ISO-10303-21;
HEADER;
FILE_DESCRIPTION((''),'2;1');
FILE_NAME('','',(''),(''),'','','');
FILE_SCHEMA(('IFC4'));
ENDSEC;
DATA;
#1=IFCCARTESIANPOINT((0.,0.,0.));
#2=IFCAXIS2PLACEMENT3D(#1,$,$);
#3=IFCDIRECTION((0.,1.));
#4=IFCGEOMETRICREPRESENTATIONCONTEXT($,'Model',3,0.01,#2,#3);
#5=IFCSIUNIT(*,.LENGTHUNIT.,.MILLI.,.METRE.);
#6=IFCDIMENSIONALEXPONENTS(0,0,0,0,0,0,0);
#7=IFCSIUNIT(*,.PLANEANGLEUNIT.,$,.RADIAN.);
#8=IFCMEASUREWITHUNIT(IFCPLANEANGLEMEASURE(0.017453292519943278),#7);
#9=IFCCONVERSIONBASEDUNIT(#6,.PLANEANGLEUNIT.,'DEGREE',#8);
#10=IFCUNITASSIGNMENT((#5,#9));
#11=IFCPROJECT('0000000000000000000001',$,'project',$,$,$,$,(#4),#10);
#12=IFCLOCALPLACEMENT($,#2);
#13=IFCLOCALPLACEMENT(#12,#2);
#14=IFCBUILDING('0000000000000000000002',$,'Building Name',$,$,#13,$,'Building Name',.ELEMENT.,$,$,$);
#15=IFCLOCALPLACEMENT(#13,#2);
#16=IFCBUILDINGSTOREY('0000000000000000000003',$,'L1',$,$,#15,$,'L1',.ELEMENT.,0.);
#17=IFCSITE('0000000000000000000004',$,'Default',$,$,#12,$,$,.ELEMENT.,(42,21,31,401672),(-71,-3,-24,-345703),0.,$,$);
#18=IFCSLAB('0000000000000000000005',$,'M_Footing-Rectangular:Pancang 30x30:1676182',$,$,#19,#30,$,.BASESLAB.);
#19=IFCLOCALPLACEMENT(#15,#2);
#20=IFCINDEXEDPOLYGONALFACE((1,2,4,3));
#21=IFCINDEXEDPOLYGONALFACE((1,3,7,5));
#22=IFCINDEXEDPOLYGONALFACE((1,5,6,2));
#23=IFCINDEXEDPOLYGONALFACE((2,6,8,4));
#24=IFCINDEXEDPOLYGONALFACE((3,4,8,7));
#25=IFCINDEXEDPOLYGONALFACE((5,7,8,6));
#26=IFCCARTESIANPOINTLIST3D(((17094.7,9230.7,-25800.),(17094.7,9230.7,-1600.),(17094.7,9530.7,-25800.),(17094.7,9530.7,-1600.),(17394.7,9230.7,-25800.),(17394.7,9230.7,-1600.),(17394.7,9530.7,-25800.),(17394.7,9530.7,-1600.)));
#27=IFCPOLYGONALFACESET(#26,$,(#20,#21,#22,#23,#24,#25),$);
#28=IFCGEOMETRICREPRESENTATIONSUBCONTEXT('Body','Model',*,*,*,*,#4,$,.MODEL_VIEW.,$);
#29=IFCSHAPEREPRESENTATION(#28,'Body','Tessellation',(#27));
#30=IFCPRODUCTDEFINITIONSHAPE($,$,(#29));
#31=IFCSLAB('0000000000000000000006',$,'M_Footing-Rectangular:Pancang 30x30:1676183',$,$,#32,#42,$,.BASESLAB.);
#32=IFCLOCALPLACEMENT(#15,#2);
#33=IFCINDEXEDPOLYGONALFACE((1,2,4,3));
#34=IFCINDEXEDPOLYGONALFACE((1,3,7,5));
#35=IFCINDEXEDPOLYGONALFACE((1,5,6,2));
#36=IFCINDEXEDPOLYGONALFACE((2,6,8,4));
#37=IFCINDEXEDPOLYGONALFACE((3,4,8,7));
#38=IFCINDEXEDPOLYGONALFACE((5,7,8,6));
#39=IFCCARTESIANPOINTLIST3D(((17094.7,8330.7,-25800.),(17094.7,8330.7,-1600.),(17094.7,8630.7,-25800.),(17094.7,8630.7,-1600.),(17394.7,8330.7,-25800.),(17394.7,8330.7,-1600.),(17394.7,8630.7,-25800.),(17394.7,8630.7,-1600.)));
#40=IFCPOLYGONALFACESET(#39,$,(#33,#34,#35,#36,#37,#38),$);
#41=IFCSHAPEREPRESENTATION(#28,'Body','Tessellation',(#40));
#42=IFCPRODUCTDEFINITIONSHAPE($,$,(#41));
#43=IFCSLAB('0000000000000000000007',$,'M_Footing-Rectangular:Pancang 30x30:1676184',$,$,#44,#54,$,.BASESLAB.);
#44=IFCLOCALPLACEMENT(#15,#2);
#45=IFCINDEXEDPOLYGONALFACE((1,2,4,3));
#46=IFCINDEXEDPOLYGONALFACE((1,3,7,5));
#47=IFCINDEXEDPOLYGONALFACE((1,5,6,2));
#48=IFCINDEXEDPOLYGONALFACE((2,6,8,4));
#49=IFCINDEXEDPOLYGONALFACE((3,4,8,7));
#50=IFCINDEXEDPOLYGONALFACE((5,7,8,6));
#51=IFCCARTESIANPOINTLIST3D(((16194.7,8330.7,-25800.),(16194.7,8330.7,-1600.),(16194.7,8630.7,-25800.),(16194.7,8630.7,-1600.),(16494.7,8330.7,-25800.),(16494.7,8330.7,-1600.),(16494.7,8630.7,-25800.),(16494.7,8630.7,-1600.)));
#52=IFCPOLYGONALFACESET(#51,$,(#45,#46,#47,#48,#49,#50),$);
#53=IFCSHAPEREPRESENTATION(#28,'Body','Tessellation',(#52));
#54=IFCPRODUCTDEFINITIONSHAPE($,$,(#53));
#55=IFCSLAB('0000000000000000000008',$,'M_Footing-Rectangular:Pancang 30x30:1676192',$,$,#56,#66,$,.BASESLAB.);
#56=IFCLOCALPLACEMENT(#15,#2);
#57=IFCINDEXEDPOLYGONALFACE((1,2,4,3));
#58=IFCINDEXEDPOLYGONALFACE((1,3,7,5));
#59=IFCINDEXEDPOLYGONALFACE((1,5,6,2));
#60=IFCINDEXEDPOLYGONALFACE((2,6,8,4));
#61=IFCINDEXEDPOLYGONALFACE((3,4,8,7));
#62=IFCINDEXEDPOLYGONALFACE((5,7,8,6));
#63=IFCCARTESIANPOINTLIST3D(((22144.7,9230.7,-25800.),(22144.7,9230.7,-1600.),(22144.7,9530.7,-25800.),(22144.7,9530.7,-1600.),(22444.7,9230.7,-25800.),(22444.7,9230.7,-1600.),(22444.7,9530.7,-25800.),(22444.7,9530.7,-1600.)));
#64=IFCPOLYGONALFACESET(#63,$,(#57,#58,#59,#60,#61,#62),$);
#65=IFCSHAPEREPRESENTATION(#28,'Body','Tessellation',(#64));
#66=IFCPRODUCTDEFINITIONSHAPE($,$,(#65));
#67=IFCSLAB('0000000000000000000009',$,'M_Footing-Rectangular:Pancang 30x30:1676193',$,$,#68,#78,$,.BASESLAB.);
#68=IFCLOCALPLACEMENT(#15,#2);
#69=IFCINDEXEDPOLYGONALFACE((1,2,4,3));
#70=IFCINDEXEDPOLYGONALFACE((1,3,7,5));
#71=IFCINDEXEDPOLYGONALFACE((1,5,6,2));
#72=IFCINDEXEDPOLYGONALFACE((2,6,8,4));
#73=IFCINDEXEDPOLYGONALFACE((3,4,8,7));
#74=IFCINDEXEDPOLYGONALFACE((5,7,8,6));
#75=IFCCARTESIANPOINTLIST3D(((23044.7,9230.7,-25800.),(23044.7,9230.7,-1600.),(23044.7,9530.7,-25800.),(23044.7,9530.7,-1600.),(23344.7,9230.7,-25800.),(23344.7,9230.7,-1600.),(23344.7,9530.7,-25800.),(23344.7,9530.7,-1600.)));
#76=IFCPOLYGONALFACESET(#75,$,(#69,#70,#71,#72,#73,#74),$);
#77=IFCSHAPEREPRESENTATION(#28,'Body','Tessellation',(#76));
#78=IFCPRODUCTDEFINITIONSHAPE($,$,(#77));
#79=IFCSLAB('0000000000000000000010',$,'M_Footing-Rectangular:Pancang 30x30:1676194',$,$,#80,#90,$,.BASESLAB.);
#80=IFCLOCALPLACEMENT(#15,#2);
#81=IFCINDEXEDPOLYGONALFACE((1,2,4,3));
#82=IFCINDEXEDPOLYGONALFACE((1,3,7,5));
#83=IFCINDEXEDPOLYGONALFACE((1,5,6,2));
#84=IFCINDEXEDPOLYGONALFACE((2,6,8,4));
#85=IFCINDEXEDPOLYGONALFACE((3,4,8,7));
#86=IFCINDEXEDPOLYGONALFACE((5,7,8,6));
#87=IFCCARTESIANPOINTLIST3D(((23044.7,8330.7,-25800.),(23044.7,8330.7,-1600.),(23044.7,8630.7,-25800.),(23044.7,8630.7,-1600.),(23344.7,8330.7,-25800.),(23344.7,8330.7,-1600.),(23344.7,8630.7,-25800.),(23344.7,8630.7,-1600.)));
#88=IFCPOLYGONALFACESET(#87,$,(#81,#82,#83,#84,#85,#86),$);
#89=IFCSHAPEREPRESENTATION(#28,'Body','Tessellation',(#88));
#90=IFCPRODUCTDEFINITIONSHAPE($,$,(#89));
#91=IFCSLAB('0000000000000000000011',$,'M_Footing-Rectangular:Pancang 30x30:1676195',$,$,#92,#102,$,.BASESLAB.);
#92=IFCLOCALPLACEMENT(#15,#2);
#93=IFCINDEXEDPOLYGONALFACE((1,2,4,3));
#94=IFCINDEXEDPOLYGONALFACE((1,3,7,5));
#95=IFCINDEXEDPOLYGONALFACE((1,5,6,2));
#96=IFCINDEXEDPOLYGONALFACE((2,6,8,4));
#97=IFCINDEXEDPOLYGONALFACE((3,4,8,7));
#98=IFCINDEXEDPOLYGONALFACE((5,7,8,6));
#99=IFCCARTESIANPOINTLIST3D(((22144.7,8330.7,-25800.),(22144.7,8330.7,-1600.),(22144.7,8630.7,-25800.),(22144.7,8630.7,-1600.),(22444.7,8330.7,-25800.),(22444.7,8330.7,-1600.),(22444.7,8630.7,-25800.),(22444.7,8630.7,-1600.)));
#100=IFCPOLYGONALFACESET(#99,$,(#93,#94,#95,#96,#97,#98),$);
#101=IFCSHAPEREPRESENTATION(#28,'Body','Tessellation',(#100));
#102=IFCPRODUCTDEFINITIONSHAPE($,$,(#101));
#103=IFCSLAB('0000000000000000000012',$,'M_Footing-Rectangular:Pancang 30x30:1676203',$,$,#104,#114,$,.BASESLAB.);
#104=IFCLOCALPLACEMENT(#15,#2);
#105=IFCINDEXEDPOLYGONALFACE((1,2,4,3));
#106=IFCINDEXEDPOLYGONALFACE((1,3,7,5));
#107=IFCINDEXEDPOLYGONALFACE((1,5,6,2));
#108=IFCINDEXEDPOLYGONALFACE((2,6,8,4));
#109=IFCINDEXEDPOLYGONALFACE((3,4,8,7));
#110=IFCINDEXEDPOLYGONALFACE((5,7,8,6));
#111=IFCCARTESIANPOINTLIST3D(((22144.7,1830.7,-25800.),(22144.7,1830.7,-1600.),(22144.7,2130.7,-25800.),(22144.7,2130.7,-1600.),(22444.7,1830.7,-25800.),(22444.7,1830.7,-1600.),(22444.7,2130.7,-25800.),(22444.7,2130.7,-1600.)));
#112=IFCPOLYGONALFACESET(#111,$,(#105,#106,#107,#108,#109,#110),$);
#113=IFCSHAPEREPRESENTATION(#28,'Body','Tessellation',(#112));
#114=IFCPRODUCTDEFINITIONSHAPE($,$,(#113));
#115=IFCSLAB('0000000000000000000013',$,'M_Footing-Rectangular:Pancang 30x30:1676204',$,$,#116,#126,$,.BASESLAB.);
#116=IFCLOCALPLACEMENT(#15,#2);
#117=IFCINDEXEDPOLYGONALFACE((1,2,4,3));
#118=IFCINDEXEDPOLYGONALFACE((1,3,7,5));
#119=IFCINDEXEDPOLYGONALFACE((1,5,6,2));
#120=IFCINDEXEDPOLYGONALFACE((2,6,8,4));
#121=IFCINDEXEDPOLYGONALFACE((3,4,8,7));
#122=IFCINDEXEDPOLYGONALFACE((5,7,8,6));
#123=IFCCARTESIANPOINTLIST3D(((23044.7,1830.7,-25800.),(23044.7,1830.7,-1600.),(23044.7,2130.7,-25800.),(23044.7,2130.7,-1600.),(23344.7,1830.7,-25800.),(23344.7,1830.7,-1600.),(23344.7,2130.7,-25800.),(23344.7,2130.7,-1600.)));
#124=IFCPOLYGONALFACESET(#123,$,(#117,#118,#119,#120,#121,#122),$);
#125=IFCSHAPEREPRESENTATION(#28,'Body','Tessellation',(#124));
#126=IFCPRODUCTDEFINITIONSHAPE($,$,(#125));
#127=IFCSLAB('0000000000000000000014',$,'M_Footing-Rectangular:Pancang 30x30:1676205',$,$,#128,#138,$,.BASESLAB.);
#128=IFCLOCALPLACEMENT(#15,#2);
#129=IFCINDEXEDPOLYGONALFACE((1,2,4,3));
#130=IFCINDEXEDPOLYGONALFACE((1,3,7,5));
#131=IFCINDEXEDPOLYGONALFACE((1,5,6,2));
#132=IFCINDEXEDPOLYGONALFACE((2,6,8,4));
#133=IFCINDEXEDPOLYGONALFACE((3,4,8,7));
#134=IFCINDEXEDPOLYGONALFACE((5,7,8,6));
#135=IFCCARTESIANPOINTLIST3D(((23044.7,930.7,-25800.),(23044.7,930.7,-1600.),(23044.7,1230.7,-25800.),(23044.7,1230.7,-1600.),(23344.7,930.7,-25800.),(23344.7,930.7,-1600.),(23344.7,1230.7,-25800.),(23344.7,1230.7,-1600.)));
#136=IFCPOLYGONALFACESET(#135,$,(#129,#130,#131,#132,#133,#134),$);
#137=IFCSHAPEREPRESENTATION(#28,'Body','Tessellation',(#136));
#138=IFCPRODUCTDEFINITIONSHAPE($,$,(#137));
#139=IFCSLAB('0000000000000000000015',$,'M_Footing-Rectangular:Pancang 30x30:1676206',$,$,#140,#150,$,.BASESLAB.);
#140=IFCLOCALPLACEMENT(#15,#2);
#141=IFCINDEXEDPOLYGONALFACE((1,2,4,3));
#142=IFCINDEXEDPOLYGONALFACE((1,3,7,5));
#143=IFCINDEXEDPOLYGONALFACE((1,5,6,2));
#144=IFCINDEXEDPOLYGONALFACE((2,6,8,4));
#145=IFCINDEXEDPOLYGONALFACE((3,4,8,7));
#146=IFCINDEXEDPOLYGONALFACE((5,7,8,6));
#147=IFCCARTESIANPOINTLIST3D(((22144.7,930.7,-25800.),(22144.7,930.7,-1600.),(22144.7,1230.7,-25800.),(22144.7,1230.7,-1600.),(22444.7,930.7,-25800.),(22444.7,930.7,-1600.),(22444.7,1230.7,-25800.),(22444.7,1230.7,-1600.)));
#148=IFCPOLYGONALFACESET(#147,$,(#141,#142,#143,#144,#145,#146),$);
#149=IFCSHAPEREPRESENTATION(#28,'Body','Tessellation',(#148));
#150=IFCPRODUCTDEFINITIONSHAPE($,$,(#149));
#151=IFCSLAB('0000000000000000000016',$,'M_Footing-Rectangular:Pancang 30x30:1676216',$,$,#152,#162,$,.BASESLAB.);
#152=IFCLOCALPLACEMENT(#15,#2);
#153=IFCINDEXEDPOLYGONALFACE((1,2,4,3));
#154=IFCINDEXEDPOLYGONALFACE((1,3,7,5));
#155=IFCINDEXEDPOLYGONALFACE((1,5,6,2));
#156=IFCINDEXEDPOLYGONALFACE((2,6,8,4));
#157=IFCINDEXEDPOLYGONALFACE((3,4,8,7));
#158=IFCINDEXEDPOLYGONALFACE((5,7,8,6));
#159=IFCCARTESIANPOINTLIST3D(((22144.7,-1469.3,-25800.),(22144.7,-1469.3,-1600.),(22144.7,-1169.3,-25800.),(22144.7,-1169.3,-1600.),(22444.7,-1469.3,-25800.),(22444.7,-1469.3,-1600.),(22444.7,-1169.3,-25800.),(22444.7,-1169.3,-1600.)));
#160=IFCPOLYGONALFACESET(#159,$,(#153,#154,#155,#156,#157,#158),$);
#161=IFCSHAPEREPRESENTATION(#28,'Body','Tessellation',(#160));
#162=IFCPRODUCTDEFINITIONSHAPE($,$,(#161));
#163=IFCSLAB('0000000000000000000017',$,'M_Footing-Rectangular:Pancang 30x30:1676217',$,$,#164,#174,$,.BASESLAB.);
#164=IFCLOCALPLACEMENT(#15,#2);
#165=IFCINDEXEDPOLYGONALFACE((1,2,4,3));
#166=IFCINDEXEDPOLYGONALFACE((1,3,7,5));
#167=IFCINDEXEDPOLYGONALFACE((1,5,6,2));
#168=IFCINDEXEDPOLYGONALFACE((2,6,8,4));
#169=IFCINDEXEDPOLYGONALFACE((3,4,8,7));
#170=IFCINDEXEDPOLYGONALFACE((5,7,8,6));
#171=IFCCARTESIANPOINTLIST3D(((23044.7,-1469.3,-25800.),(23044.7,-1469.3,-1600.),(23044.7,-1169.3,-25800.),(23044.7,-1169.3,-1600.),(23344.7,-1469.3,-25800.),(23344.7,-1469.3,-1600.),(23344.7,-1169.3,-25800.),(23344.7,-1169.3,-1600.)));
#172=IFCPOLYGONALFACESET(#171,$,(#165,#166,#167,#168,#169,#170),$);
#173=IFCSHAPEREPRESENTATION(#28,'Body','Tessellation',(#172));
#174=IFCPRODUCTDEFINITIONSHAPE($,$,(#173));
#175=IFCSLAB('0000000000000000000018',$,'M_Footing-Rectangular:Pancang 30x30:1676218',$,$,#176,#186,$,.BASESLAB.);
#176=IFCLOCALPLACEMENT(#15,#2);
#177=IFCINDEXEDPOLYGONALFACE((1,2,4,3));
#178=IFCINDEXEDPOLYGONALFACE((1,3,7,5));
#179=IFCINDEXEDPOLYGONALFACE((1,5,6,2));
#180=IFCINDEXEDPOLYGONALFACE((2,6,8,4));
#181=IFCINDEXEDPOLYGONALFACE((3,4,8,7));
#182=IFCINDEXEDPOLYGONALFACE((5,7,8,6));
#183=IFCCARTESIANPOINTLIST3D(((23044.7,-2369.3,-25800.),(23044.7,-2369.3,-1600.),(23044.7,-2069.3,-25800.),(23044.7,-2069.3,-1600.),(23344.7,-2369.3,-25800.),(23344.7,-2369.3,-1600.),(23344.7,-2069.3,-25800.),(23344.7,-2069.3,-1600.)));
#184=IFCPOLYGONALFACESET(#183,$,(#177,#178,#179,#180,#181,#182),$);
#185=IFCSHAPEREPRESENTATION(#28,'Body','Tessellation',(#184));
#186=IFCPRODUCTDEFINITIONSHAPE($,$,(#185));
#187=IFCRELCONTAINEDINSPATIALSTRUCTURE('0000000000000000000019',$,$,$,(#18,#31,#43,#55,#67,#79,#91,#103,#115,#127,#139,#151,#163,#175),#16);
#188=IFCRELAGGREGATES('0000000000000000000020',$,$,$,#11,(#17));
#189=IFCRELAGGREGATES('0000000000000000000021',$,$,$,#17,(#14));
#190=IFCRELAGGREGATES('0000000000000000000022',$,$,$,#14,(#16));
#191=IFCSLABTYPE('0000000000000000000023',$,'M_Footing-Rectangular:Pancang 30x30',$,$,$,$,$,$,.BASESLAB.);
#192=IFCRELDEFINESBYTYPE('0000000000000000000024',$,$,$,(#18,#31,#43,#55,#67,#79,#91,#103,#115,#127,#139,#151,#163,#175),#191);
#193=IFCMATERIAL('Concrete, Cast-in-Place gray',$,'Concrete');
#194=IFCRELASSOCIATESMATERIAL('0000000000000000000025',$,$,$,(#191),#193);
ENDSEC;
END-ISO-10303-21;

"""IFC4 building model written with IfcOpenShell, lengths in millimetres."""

from ifc_helpers import new_model, entity, si_unit, converted_unit, direction, frame, origin, place, context, subcontext, project, spatial, indexed_curve, outline, extrude, material, type_object, element, save


model = new_model("IFC4")

# Units and contexts
model_context = context("Model", 3, precision=0.01, world=origin(), true_north=direction((0.0, 1.0)))
body_context = subcontext(model_context, "Body", "Model", "MODEL_VIEW")
ifc_project = project(units=[si_unit("LENGTHUNIT", "METRE", prefix="MILLI"), converted_unit("PLANEANGLEUNIT", "DEGREE", entity("IfcPlaneAngleMeasure", 0.017453292519943278), si_unit("PLANEANGLEUNIT", "RADIAN"), dimensions=[0, 0, 0, 0, 0, 0, 0])], contexts=[model_context])

# Site, building, storey
site_placement = place(None, origin())
site = spatial("IfcSite", under=ifc_project, at=site_placement, Name="Default", CompositionType="ELEMENT", RefLatitude=(42, 21, 31, 401672), RefLongitude=(-71, -3, -24, -345703), RefElevation=0.0)
building_placement = place(site_placement, origin())
building = spatial("IfcBuilding", under=site, at=building_placement, Name="Building Name", LongName="Building Name", CompositionType="ELEMENT")
storey_placement = place(building_placement, origin())
storey = spatial("IfcBuildingStorey", under=building, at=storey_placement, Name="L1", LongName="L1", CompositionType="ELEMENT", Elevation=0.0)

# Slabs
ifc_material = material(Name="Concrete, Cast-in-Place gray", Category="Concrete")
slab_type = type_object("IfcSlabType", Name="M_Footing-Rectangular:Pancang 30x30", PredefinedType="BASESLAB", material=ifc_material)
slab_1_placement = place(storey_placement, origin())
element("IfcSlab", 1, at=slab_1_placement, inside=storey, type_object=slab_type, Name="M_Footing-Rectangular:Pancang 30x30:1676182", PredefinedType="BASESLAB", context=body_context, shape_type="SweptSolid", body=[
    extrude(outline(indexed_curve([(-150.0, -150.0), (150.0, -150.0), (150.0, 150.0), (-150.0, 150.0), (-150.0, -150.0)], self_intersect=False)), frame((17244.7, 9380.7, -25800.0), z_axis=(0.0, 0.0, 1.0), x_axis=(-1.0, 0.0, 0.0)), (0.0, 0.0, 1.0), 24200.0),
])
slab_2_placement = place(storey_placement, origin())
element("IfcSlab", 2, at=slab_2_placement, inside=storey, type_object=slab_type, Name="M_Footing-Rectangular:Pancang 30x30:1676183", PredefinedType="BASESLAB", context=body_context, shape_type="SweptSolid", body=[
    extrude(outline(indexed_curve([(-150.0, -150.0), (150.0, -150.0), (150.0, 150.0), (-150.0, 150.0), (-150.0, -150.0)], self_intersect=False)), frame((17244.7, 8480.7, -25800.0), z_axis=(0.0, 0.0, 1.0), x_axis=(-1.0, 0.0, 0.0)), (0.0, 0.0, 1.0), 24200.0),
])
slab_3_placement = place(storey_placement, origin())
element("IfcSlab", 3, at=slab_3_placement, inside=storey, type_object=slab_type, Name="M_Footing-Rectangular:Pancang 30x30:1676184", PredefinedType="BASESLAB", context=body_context, shape_type="SweptSolid", body=[
    extrude(outline(indexed_curve([(-150.0, -150.0), (150.0, -150.0), (150.0, 150.0), (-150.0, 150.0), (-150.0, -150.0)], self_intersect=False)), frame((16344.7, 8480.7, -25800.0), z_axis=(0.0, 0.0, 1.0), x_axis=(-1.0, 0.0, 0.0)), (0.0, 0.0, 1.0), 24200.0),
])
slab_4_placement = place(storey_placement, origin())
element("IfcSlab", 4, at=slab_4_placement, inside=storey, type_object=slab_type, Name="M_Footing-Rectangular:Pancang 30x30:1676192", PredefinedType="BASESLAB", context=body_context, shape_type="SweptSolid", body=[
    extrude(outline(indexed_curve([(-150.0, -150.0), (150.0, -150.0), (150.0, 150.0), (-150.0, 150.0), (-150.0, -150.0)], self_intersect=False)), frame((22294.7, 9380.7, -25800.0), z_axis=(0.0, 0.0, 1.0), x_axis=(-1.0, 0.0, 0.0)), (0.0, 0.0, 1.0), 24200.0),
])
slab_5_placement = place(storey_placement, origin())
element("IfcSlab", 5, at=slab_5_placement, inside=storey, type_object=slab_type, Name="M_Footing-Rectangular:Pancang 30x30:1676193", PredefinedType="BASESLAB", context=body_context, shape_type="SweptSolid", body=[
    extrude(outline(indexed_curve([(-150.0, -150.0), (150.0, -150.0), (150.0, 150.0), (-150.0, 150.0), (-150.0, -150.0)], self_intersect=False)), frame((23194.7, 9380.7, -25800.0), z_axis=(0.0, 0.0, 1.0), x_axis=(-1.0, 0.0, 0.0)), (0.0, 0.0, 1.0), 24200.0),
])
slab_6_placement = place(storey_placement, origin())
element("IfcSlab", 6, at=slab_6_placement, inside=storey, type_object=slab_type, Name="M_Footing-Rectangular:Pancang 30x30:1676194", PredefinedType="BASESLAB", context=body_context, shape_type="SweptSolid", body=[
    extrude(outline(indexed_curve([(-150.0, -150.0), (150.0, -150.0), (150.0, 150.0), (-150.0, 150.0), (-150.0, -150.0)], self_intersect=False)), frame((23194.7, 8480.7, -25800.0), z_axis=(0.0, 0.0, 1.0), x_axis=(-1.0, 0.0, 0.0)), (0.0, 0.0, 1.0), 24200.0),
])
slab_7_placement = place(storey_placement, origin())
element("IfcSlab", 7, at=slab_7_placement, inside=storey, type_object=slab_type, Name="M_Footing-Rectangular:Pancang 30x30:1676195", PredefinedType="BASESLAB", context=body_context, shape_type="SweptSolid", body=[
    extrude(outline(indexed_curve([(-150.0, -150.0), (150.0, -150.0), (150.0, 150.0), (-150.0, 150.0), (-150.0, -150.0)], self_intersect=False)), frame((22294.7, 8480.7, -25800.0), z_axis=(0.0, 0.0, 1.0), x_axis=(-1.0, 0.0, 0.0)), (0.0, 0.0, 1.0), 24200.0),
])
slab_8_placement = place(storey_placement, origin())
element("IfcSlab", 8, at=slab_8_placement, inside=storey, type_object=slab_type, Name="M_Footing-Rectangular:Pancang 30x30:1676203", PredefinedType="BASESLAB", context=body_context, shape_type="SweptSolid", body=[
    extrude(outline(indexed_curve([(-150.0, -150.0), (150.0, -150.0), (150.0, 150.0), (-150.0, 150.0), (-150.0, -150.0)], self_intersect=False)), frame((22294.7, 1980.7, -25800.0), z_axis=(0.0, 0.0, 1.0), x_axis=(-1.0, 0.0, 0.0)), (0.0, 0.0, 1.0), 24200.0),
])
slab_9_placement = place(storey_placement, origin())
element("IfcSlab", 9, at=slab_9_placement, inside=storey, type_object=slab_type, Name="M_Footing-Rectangular:Pancang 30x30:1676204", PredefinedType="BASESLAB", context=body_context, shape_type="SweptSolid", body=[
    extrude(outline(indexed_curve([(-150.0, -150.0), (150.0, -150.0), (150.0, 150.0), (-150.0, 150.0), (-150.0, -150.0)], self_intersect=False)), frame((23194.7, 1980.7, -25800.0), z_axis=(0.0, 0.0, 1.0), x_axis=(-1.0, 0.0, 0.0)), (0.0, 0.0, 1.0), 24200.0),
])
slab_10_placement = place(storey_placement, origin())
element("IfcSlab", 10, at=slab_10_placement, inside=storey, type_object=slab_type, Name="M_Footing-Rectangular:Pancang 30x30:1676205", PredefinedType="BASESLAB", context=body_context, shape_type="SweptSolid", body=[
    extrude(outline(indexed_curve([(-150.0, -150.0), (150.0, -150.0), (150.0, 150.0), (-150.0, 150.0), (-150.0, -150.0)], self_intersect=False)), frame((23194.7, 1080.7, -25800.0), z_axis=(0.0, 0.0, 1.0), x_axis=(-1.0, 0.0, 0.0)), (0.0, 0.0, 1.0), 24200.0),
])
slab_11_placement = place(storey_placement, origin())
element("IfcSlab", 11, at=slab_11_placement, inside=storey, type_object=slab_type, Name="M_Footing-Rectangular:Pancang 30x30:1676206", PredefinedType="BASESLAB", context=body_context, shape_type="SweptSolid", body=[
    extrude(outline(indexed_curve([(-150.0, -150.0), (150.0, -150.0), (150.0, 150.0), (-150.0, 150.0), (-150.0, -150.0)], self_intersect=False)), frame((22294.7, 1080.7, -25800.0), z_axis=(0.0, 0.0, 1.0), x_axis=(-1.0, 0.0, 0.0)), (0.0, 0.0, 1.0), 24200.0),
])
slab_12_placement = place(storey_placement, origin())
element("IfcSlab", 12, at=slab_12_placement, inside=storey, type_object=slab_type, Name="M_Footing-Rectangular:Pancang 30x30:1676216", PredefinedType="BASESLAB", context=body_context, shape_type="SweptSolid", body=[
    extrude(outline(indexed_curve([(-150.0, -150.0), (150.0, -150.0), (150.0, 150.0), (-150.0, 150.0), (-150.0, -150.0)], self_intersect=False)), frame((22294.7, -1319.3, -25800.0), z_axis=(0.0, 0.0, 1.0), x_axis=(-1.0, 0.0, 0.0)), (0.0, 0.0, 1.0), 24200.0),
])
slab_13_placement = place(storey_placement, origin())
element("IfcSlab", 13, at=slab_13_placement, inside=storey, type_object=slab_type, Name="M_Footing-Rectangular:Pancang 30x30:1676217", PredefinedType="BASESLAB", context=body_context, shape_type="SweptSolid", body=[
    extrude(outline(indexed_curve([(-150.0, -150.0), (150.0, -150.0), (150.0, 150.0), (-150.0, 150.0), (-150.0, -150.0)], self_intersect=False)), frame((23194.7, -1319.3, -25800.0), z_axis=(0.0, 0.0, 1.0), x_axis=(-1.0, 0.0, 0.0)), (0.0, 0.0, 1.0), 24200.0),
])
slab_14_placement = place(storey_placement, origin())
element("IfcSlab", 14, at=slab_14_placement, inside=storey, type_object=slab_type, Name="M_Footing-Rectangular:Pancang 30x30:1676218", PredefinedType="BASESLAB", context=body_context, shape_type="SweptSolid", body=[
    extrude(outline(indexed_curve([(-150.0, -150.0), (150.0, -150.0), (150.0, 150.0), (-150.0, 150.0), (-150.0, -150.0)], self_intersect=False)), frame((23194.7, -2219.3, -25800.0), z_axis=(0.0, 0.0, 1.0), x_axis=(-1.0, 0.0, 0.0)), (0.0, 0.0, 1.0), 24200.0),
])

save(model, "model.ifc")
